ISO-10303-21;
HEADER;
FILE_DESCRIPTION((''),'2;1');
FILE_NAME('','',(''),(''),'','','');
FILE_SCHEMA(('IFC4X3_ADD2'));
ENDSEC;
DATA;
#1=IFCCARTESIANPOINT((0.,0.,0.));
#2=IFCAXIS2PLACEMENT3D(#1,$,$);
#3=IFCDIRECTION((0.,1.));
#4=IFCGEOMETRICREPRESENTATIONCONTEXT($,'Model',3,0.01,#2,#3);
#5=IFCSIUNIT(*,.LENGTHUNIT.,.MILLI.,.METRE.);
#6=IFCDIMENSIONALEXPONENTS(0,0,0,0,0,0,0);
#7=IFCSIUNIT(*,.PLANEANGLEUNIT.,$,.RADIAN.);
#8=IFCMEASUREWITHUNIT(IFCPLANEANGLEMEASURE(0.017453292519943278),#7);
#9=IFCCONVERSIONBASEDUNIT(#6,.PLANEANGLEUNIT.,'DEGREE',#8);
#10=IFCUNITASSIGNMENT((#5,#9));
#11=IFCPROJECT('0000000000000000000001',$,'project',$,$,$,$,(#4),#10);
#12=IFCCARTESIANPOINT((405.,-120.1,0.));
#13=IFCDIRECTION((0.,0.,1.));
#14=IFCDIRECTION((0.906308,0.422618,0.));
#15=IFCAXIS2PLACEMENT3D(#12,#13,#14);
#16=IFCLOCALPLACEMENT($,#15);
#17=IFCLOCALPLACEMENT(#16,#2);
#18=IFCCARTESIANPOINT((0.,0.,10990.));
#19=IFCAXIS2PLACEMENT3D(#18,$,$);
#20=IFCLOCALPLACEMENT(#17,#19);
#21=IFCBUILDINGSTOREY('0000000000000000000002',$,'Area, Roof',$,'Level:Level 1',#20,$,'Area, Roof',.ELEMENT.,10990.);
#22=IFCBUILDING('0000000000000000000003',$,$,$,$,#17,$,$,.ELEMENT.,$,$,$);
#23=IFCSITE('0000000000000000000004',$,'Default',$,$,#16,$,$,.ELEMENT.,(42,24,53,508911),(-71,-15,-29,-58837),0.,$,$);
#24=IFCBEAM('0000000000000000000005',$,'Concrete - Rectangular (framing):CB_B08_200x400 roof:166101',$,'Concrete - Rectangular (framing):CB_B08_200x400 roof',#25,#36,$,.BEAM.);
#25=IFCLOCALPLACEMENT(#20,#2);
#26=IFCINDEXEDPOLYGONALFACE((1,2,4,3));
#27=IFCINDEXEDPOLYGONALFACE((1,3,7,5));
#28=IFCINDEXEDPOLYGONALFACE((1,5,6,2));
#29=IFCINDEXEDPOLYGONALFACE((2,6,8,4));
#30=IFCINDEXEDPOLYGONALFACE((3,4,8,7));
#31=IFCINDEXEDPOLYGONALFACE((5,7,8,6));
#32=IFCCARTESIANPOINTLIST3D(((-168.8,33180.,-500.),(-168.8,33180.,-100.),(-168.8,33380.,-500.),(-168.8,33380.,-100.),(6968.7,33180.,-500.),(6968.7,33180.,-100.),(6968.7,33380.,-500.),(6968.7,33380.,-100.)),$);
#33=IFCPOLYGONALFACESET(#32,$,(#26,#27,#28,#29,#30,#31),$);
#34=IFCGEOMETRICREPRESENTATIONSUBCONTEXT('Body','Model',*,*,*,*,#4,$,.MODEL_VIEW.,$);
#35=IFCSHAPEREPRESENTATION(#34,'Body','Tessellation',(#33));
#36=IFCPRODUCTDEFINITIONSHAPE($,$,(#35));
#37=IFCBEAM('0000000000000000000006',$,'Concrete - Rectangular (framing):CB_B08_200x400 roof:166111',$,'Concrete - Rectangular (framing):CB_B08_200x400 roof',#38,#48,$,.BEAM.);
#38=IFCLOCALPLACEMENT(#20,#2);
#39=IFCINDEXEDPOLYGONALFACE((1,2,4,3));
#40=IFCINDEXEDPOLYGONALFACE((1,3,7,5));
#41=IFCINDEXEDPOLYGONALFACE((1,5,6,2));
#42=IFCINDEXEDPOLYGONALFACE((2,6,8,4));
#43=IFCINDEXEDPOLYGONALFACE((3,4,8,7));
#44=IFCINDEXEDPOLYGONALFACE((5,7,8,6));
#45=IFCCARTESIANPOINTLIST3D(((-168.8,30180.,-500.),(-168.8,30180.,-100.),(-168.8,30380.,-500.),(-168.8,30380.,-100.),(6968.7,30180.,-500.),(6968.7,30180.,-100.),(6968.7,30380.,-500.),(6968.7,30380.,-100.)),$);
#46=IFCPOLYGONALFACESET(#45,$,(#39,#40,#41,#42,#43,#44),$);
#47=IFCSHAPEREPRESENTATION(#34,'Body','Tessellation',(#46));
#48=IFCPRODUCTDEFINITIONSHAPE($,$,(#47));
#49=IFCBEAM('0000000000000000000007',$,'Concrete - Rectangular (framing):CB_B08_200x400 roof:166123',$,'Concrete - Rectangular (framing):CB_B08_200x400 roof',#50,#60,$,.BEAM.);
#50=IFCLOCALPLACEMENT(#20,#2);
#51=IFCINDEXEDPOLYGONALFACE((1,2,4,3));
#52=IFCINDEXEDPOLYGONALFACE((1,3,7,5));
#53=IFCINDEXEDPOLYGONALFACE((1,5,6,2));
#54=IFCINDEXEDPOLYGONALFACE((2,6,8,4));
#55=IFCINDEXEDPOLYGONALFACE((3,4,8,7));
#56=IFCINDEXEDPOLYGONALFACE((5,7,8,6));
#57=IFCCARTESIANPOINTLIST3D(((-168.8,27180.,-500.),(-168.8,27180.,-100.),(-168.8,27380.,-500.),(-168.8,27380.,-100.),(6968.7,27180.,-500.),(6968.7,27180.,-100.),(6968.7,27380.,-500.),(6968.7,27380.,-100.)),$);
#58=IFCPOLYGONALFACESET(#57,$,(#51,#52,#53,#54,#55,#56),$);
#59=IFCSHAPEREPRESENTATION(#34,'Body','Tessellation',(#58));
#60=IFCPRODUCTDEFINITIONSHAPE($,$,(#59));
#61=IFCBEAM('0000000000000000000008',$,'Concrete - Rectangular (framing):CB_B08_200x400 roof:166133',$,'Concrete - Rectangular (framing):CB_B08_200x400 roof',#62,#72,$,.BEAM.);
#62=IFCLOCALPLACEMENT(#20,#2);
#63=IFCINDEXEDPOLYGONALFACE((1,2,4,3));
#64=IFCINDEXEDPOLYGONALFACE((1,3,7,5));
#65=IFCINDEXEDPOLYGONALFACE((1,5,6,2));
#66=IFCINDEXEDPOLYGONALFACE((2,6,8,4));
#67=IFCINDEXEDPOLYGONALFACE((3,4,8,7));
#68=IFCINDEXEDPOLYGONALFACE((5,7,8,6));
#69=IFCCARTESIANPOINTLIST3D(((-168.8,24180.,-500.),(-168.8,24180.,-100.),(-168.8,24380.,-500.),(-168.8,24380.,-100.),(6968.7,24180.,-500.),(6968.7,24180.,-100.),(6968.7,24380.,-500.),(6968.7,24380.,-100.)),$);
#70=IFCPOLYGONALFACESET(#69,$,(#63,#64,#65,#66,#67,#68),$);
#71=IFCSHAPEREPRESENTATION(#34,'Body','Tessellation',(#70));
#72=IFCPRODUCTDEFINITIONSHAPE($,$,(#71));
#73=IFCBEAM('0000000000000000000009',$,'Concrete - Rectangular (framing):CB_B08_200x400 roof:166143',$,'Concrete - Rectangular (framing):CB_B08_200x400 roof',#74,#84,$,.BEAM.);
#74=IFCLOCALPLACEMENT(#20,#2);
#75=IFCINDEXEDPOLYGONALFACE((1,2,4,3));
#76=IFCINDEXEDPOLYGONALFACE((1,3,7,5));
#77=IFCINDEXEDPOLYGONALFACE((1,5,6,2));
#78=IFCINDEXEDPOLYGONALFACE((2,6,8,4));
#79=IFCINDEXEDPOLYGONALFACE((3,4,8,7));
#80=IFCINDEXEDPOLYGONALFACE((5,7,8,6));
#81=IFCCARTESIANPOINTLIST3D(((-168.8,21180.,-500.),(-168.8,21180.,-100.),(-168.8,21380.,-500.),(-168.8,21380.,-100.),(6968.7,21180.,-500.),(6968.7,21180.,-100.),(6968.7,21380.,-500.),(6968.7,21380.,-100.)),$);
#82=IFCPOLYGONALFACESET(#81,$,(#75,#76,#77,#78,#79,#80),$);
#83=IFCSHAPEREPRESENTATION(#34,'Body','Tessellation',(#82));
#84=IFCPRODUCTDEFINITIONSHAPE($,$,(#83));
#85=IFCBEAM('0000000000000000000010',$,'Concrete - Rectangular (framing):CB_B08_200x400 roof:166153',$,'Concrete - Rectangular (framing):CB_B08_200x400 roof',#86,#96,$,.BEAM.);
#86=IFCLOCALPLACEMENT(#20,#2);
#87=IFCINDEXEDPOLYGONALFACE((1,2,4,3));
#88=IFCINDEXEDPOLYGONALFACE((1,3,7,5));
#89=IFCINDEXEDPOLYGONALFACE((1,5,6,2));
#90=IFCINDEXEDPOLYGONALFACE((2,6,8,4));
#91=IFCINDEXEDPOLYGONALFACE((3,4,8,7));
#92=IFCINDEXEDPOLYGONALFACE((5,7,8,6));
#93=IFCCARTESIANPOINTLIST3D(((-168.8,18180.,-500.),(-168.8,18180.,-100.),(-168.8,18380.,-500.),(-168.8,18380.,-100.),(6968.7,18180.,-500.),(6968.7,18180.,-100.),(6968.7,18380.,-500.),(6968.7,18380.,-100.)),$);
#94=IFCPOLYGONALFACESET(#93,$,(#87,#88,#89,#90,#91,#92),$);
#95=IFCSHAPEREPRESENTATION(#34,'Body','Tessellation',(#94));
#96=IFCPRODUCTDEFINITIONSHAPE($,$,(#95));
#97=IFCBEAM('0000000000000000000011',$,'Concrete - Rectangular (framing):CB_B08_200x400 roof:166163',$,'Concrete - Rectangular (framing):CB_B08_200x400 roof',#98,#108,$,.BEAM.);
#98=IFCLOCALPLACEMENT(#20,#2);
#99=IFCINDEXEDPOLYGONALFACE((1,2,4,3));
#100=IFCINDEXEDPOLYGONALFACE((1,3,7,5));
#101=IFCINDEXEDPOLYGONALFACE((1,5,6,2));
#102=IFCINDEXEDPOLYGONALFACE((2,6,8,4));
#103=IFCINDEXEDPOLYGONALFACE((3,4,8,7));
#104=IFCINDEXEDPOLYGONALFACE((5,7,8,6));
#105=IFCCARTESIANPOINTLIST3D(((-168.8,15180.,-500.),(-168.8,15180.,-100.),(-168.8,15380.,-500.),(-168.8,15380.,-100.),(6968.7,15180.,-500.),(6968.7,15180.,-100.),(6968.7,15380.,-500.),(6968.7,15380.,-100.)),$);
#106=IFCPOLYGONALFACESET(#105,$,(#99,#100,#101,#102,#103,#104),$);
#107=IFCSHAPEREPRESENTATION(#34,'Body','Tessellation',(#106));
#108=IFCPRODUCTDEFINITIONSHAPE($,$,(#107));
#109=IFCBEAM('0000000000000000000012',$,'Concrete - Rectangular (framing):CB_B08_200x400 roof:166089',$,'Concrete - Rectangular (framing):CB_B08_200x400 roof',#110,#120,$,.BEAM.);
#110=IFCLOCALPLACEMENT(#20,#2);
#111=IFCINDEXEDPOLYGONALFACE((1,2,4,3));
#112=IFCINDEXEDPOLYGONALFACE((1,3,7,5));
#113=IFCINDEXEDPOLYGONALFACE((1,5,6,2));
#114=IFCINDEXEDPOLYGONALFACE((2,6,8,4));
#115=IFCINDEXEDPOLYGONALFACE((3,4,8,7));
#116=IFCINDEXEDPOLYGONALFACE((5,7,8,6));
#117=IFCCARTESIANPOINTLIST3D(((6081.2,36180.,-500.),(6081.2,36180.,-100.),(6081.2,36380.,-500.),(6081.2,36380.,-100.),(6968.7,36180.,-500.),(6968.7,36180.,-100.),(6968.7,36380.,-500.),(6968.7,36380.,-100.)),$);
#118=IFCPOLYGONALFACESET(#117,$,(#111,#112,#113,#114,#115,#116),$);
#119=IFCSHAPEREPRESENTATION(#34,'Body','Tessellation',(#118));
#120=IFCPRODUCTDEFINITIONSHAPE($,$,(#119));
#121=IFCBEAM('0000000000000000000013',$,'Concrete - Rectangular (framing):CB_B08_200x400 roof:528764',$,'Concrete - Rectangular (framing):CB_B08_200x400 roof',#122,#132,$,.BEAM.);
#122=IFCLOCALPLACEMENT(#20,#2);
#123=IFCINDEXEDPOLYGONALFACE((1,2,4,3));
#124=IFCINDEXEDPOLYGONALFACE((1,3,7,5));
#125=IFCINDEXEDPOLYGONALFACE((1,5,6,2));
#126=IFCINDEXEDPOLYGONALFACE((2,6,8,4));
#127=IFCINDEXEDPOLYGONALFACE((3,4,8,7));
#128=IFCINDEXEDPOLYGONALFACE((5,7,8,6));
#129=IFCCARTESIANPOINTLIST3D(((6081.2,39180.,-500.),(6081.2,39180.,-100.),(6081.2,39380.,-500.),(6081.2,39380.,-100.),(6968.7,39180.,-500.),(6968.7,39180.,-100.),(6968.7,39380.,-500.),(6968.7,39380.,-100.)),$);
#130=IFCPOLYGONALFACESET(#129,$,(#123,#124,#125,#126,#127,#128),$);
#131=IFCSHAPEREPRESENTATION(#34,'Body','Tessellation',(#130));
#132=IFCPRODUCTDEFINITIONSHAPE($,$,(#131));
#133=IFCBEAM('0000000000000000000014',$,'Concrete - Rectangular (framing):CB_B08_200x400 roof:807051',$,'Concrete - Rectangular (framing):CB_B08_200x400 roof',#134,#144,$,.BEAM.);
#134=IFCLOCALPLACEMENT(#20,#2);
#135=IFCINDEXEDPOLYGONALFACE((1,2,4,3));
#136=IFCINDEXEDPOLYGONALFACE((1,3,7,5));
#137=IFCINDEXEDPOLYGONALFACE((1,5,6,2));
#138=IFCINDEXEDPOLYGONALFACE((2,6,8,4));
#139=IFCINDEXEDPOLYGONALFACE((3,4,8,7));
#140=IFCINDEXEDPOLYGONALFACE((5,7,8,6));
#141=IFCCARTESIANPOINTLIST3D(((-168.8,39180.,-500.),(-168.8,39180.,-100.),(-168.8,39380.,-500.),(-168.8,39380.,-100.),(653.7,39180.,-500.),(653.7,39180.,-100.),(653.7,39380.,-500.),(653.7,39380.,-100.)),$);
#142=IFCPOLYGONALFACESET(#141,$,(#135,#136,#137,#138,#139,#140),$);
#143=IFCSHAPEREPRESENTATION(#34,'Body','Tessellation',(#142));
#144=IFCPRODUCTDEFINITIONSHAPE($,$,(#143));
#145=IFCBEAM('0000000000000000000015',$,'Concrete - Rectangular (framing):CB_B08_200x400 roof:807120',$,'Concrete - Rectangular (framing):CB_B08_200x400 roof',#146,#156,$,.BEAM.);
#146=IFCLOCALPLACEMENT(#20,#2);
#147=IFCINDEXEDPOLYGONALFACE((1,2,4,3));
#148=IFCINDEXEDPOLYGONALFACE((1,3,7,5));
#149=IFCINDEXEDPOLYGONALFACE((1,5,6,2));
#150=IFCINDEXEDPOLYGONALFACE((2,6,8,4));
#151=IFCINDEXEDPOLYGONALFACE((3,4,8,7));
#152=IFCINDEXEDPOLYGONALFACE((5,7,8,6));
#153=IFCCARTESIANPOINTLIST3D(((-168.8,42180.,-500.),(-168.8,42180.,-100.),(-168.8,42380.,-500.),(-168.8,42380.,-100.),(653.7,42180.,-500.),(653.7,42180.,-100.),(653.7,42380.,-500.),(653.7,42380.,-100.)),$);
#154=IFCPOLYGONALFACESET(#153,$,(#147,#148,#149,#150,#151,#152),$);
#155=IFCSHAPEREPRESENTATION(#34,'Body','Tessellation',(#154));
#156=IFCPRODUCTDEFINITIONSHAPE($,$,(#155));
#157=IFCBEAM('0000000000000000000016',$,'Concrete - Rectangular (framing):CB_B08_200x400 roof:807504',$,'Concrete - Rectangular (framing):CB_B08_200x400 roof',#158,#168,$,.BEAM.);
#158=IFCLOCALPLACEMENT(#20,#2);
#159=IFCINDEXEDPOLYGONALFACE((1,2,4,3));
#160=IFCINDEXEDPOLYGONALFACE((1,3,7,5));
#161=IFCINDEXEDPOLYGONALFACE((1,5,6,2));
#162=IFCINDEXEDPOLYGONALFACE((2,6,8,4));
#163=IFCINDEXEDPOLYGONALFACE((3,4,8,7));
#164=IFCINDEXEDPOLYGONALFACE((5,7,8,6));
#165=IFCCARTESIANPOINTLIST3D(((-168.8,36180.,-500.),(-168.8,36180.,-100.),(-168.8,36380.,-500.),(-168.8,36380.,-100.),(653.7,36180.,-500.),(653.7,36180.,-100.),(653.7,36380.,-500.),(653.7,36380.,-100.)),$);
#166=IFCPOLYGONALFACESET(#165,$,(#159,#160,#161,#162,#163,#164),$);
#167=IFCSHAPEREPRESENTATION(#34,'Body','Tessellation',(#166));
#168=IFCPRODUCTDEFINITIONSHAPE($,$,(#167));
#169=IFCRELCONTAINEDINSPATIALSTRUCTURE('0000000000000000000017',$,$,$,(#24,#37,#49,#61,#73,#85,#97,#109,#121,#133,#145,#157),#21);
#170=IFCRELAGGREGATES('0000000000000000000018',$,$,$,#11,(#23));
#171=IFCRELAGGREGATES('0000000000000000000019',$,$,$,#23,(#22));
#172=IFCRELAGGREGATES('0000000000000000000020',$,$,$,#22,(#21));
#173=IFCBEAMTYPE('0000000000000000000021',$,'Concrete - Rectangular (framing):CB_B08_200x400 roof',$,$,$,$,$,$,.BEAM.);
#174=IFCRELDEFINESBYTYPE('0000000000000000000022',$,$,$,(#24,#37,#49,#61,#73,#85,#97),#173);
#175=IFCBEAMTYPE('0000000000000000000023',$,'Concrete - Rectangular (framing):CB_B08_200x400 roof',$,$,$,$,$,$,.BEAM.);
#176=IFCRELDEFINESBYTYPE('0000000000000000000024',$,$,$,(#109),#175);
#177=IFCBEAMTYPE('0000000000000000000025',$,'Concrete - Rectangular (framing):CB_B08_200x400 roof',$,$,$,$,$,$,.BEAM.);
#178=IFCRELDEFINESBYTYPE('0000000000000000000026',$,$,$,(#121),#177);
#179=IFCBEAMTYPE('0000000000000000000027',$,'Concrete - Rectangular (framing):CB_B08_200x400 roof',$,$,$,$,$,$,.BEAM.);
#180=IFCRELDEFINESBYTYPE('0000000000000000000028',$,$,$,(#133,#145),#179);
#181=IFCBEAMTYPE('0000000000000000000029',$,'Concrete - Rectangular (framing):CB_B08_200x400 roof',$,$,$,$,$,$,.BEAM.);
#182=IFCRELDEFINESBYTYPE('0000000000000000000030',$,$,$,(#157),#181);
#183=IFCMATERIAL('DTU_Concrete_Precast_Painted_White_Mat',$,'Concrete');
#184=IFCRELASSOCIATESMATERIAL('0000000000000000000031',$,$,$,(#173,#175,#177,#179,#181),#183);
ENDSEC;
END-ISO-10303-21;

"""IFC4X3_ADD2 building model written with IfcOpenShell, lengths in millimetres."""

from ifc_helpers import new_model, entity, si_unit, converted_unit, direction, frame, frame_2d, origin, origin_2d_with_axis, place, context, subcontext, project, spatial, rectangle, extrude, source, transform, mapped, material, material_profile, profile_set, type_object, type_shapes, element, save


model = new_model("IFC4X3_ADD2")

# Units and contexts
model_context = context("Model", 3, precision=0.01, world=origin(), true_north=direction((0.0, 1.0)))
body_context = subcontext(model_context, "Body", "Model", "MODEL_VIEW")
ifc_project = project(units=[si_unit("LENGTHUNIT", "METRE", prefix="MILLI"), converted_unit("PLANEANGLEUNIT", "DEGREE", entity("IfcPlaneAngleMeasure", 0.017453292519943278), si_unit("PLANEANGLEUNIT", "RADIAN"), dimensions=[0, 0, 0, 0, 0, 0, 0])], contexts=[model_context])

# Site, building, storey
site_placement = place(None, frame((405.0, -120.1, 0.0), z_axis=(0.0, 0.0, 1.0), x_axis=(0.906308, 0.422618, 0.0)))
site = spatial("IfcSite", under=ifc_project, at=site_placement, Name="Default", CompositionType="ELEMENT", RefLatitude=(42, 24, 53, 508911), RefLongitude=(-71, -15, -29, -58837), RefElevation=0.0)
building_placement = place(site_placement, origin())
building = spatial("IfcBuilding", under=site, at=building_placement, CompositionType="ELEMENT")
storey_placement = place(building_placement, frame((0.0, 0.0, 10990.0)))
storey = spatial("IfcBuildingStorey", under=building, at=storey_placement, Name="Area, Roof", ObjectType="Level:Level 1", LongName="Area, Roof", CompositionType="ELEMENT", Elevation=10990.0)

# Beams
ifc_material = material(Name="DTU_Concrete_Precast_Painted_White_Mat", Category="Concrete")
ifc_material_profile = material_profile(ifc_material, rectangle(XDim=7137.5, YDim=200.0, at=origin_2d_with_axis()), Name="CB_B08_200x400 roof")
ifc_profile_set = profile_set([ifc_material_profile], Name="CB_B08_200x400 roof")
beam_type_1 = type_object("IfcBeamType", Name="Concrete - Rectangular (framing):CB_B08_200x400 roof", PredefinedType="BEAM", material=ifc_profile_set)
shared_shape_1 = source(origin(), body_context, "Body", "SweptSolid", [
    extrude(rectangle(XDim=7137.5, YDim=200.0, at=origin_2d_with_axis()), frame((6.3, 0.0, -200.0), z_axis=(0.0, 0.0, 1.0), x_axis=(-1.0, 0.0, 0.0)), (0.0, 0.0, 1.0), 400.0),
])
type_shapes(beam_type_1, [shared_shape_1])
for number, where, z_axis, x_axis, name in (
    (1, (3406.2, 33280.0, -300.0), (0.0, 0.0, 1.0), (-1.0, 0.0, 0.0), "Concrete - Rectangular (framing):CB_B08_200x400 roof:166101"),
    (2, (3406.2, 30280.0, -300.0), (0.0, 0.0, 1.0), (-1.0, 0.0, 0.0), "Concrete - Rectangular (framing):CB_B08_200x400 roof:166111"),
    (3, (3406.2, 27280.0, -300.0), (0.0, 0.0, 1.0), (-1.0, 0.0, 0.0), "Concrete - Rectangular (framing):CB_B08_200x400 roof:166123"),
    (4, (3406.2, 24280.0, -300.0), (0.0, 0.0, 1.0), (-1.0, 0.0, 0.0), "Concrete - Rectangular (framing):CB_B08_200x400 roof:166133"),
    (5, (3406.2, 21280.0, -300.0), (0.0, 0.0, 1.0), (-1.0, 0.0, 0.0), "Concrete - Rectangular (framing):CB_B08_200x400 roof:166143"),
    (6, (3406.2, 18280.0, -300.0), (0.0, 0.0, 1.0), (-1.0, 0.0, 0.0), "Concrete - Rectangular (framing):CB_B08_200x400 roof:166153"),
    (7, (3406.2, 15280.0, -300.0), (0.0, 0.0, 1.0), (-1.0, 0.0, 0.0), "Concrete - Rectangular (framing):CB_B08_200x400 roof:166163"),
):
    element("IfcBeam", number, at=place(storey_placement, frame(where, z_axis=z_axis, x_axis=x_axis)), inside=storey, type_object=beam_type_1, Name=name, ObjectType="Concrete - Rectangular (framing):CB_B08_200x400 roof", PredefinedType="BEAM", context=body_context, shape_type="MappedRepresentation", body=[
        mapped(shared_shape_1, transform((0.0, 0.0, 0.0), scale=1.0)),
    ])
beam_type_2 = type_object("IfcBeamType", Name="Concrete - Rectangular (framing):CB_B08_200x400 roof", PredefinedType="BEAM", material=ifc_profile_set)
shared_shape_2 = source(origin(), body_context, "Body", "SweptSolid", [
    extrude(rectangle(XDim=887.5, YDim=200.0, at=frame_2d((0.0, 0.0), x_axis=(1.0, 0.0))), frame((443.8, 100.0, 0.0), z_axis=(0.0, 0.0, 1.0), x_axis=(-1.0, 0.0, 0.0)), (0.0, 0.0, 1.0), 400.0),
])
type_shapes(beam_type_2, [shared_shape_2])
beam_1_placement = place(storey_placement, frame((6968.7, 36380.0, -500.0), z_axis=(0.0, 0.0, 1.0), x_axis=(-1.0, 0.0, 0.0)))
element("IfcBeam", 8, at=beam_1_placement, inside=storey, type_object=beam_type_2, Name="Concrete - Rectangular (framing):CB_B08_200x400 roof:166089", ObjectType="Concrete - Rectangular (framing):CB_B08_200x400 roof", PredefinedType="BEAM", context=body_context, shape_type="MappedRepresentation", body=[
    mapped(shared_shape_2, transform((0.0, 0.0, 0.0), scale=1.0)),
])
beam_type_3 = type_object("IfcBeamType", Name="Concrete - Rectangular (framing):CB_B08_200x400 roof", PredefinedType="BEAM", material=ifc_profile_set)
shared_shape_3 = source(origin(), body_context, "Body", "SweptSolid", [
    extrude(rectangle(XDim=887.5, YDim=200.0, at=origin_2d_with_axis()), frame((443.8, 100.0, 0.0), z_axis=(0.0, 0.0, 1.0), x_axis=(-1.0, 0.0, 0.0)), (0.0, 0.0, 1.0), 400.0),
])
type_shapes(beam_type_3, [shared_shape_3])
beam_2_placement = place(storey_placement, frame((6968.7, 39380.0, -500.0), z_axis=(0.0, 0.0, 1.0), x_axis=(-1.0, 0.0, 0.0)))
element("IfcBeam", 9, at=beam_2_placement, inside=storey, type_object=beam_type_3, Name="Concrete - Rectangular (framing):CB_B08_200x400 roof:528764", ObjectType="Concrete - Rectangular (framing):CB_B08_200x400 roof", PredefinedType="BEAM", context=body_context, shape_type="MappedRepresentation", body=[
    mapped(shared_shape_3, transform((0.0, 0.0, 0.0), scale=1.0)),
])
beam_type_4 = type_object("IfcBeamType", Name="Concrete - Rectangular (framing):CB_B08_200x400 roof", PredefinedType="BEAM", material=ifc_profile_set)
shared_shape_4 = source(origin(), body_context, "Body", "SweptSolid", [
    extrude(rectangle(XDim=822.5, YDim=200.0, at=origin_2d_with_axis()), frame((411.2, 100.0, 0.0), z_axis=(0.0, 0.0, 1.0), x_axis=(-1.0, 0.0, 0.0)), (0.0, 0.0, 1.0), 400.0),
])
type_shapes(beam_type_4, [shared_shape_4])
for number, where, z_axis, x_axis, name in (
    (10, (653.7, 39380.0, -500.0), (0.0, 0.0, 1.0), (-1.0, 0.0, 0.0), "Concrete - Rectangular (framing):CB_B08_200x400 roof:807051"),
    (11, (653.7, 42380.0, -500.0), (0.0, 0.0, 1.0), (-1.0, 0.0, 0.0), "Concrete - Rectangular (framing):CB_B08_200x400 roof:807120"),
):
    element("IfcBeam", number, at=place(storey_placement, frame(where, z_axis=z_axis, x_axis=x_axis)), inside=storey, type_object=beam_type_4, Name=name, ObjectType="Concrete - Rectangular (framing):CB_B08_200x400 roof", PredefinedType="BEAM", context=body_context, shape_type="MappedRepresentation", body=[
        mapped(shared_shape_4, transform((0.0, 0.0, 0.0), scale=1.0)),
    ])
beam_type_5 = type_object("IfcBeamType", Name="Concrete - Rectangular (framing):CB_B08_200x400 roof", PredefinedType="BEAM", material=ifc_profile_set)
shared_shape_5 = source(origin(), body_context, "Body", "SweptSolid", [
    extrude(rectangle(XDim=822.5, YDim=200.0, at=frame_2d((0.0, 0.0), x_axis=(1.0, 0.0))), frame((411.2, 100.0, 0.0), z_axis=(0.0, 0.0, 1.0), x_axis=(-1.0, 0.0, 0.0)), (0.0, 0.0, 1.0), 400.0),
])
type_shapes(beam_type_5, [shared_shape_5])
beam_3_placement = place(storey_placement, frame((653.7, 36380.0, -500.0), z_axis=(0.0, 0.0, 1.0), x_axis=(-1.0, 0.0, 0.0)))
element("IfcBeam", 12, at=beam_3_placement, inside=storey, type_object=beam_type_5, Name="Concrete - Rectangular (framing):CB_B08_200x400 roof:807504", ObjectType="Concrete - Rectangular (framing):CB_B08_200x400 roof", PredefinedType="BEAM", context=body_context, shape_type="MappedRepresentation", body=[
    mapped(shared_shape_5, transform((0.0, 0.0, 0.0), scale=1.0)),
])

save(model, "model.ifc")
